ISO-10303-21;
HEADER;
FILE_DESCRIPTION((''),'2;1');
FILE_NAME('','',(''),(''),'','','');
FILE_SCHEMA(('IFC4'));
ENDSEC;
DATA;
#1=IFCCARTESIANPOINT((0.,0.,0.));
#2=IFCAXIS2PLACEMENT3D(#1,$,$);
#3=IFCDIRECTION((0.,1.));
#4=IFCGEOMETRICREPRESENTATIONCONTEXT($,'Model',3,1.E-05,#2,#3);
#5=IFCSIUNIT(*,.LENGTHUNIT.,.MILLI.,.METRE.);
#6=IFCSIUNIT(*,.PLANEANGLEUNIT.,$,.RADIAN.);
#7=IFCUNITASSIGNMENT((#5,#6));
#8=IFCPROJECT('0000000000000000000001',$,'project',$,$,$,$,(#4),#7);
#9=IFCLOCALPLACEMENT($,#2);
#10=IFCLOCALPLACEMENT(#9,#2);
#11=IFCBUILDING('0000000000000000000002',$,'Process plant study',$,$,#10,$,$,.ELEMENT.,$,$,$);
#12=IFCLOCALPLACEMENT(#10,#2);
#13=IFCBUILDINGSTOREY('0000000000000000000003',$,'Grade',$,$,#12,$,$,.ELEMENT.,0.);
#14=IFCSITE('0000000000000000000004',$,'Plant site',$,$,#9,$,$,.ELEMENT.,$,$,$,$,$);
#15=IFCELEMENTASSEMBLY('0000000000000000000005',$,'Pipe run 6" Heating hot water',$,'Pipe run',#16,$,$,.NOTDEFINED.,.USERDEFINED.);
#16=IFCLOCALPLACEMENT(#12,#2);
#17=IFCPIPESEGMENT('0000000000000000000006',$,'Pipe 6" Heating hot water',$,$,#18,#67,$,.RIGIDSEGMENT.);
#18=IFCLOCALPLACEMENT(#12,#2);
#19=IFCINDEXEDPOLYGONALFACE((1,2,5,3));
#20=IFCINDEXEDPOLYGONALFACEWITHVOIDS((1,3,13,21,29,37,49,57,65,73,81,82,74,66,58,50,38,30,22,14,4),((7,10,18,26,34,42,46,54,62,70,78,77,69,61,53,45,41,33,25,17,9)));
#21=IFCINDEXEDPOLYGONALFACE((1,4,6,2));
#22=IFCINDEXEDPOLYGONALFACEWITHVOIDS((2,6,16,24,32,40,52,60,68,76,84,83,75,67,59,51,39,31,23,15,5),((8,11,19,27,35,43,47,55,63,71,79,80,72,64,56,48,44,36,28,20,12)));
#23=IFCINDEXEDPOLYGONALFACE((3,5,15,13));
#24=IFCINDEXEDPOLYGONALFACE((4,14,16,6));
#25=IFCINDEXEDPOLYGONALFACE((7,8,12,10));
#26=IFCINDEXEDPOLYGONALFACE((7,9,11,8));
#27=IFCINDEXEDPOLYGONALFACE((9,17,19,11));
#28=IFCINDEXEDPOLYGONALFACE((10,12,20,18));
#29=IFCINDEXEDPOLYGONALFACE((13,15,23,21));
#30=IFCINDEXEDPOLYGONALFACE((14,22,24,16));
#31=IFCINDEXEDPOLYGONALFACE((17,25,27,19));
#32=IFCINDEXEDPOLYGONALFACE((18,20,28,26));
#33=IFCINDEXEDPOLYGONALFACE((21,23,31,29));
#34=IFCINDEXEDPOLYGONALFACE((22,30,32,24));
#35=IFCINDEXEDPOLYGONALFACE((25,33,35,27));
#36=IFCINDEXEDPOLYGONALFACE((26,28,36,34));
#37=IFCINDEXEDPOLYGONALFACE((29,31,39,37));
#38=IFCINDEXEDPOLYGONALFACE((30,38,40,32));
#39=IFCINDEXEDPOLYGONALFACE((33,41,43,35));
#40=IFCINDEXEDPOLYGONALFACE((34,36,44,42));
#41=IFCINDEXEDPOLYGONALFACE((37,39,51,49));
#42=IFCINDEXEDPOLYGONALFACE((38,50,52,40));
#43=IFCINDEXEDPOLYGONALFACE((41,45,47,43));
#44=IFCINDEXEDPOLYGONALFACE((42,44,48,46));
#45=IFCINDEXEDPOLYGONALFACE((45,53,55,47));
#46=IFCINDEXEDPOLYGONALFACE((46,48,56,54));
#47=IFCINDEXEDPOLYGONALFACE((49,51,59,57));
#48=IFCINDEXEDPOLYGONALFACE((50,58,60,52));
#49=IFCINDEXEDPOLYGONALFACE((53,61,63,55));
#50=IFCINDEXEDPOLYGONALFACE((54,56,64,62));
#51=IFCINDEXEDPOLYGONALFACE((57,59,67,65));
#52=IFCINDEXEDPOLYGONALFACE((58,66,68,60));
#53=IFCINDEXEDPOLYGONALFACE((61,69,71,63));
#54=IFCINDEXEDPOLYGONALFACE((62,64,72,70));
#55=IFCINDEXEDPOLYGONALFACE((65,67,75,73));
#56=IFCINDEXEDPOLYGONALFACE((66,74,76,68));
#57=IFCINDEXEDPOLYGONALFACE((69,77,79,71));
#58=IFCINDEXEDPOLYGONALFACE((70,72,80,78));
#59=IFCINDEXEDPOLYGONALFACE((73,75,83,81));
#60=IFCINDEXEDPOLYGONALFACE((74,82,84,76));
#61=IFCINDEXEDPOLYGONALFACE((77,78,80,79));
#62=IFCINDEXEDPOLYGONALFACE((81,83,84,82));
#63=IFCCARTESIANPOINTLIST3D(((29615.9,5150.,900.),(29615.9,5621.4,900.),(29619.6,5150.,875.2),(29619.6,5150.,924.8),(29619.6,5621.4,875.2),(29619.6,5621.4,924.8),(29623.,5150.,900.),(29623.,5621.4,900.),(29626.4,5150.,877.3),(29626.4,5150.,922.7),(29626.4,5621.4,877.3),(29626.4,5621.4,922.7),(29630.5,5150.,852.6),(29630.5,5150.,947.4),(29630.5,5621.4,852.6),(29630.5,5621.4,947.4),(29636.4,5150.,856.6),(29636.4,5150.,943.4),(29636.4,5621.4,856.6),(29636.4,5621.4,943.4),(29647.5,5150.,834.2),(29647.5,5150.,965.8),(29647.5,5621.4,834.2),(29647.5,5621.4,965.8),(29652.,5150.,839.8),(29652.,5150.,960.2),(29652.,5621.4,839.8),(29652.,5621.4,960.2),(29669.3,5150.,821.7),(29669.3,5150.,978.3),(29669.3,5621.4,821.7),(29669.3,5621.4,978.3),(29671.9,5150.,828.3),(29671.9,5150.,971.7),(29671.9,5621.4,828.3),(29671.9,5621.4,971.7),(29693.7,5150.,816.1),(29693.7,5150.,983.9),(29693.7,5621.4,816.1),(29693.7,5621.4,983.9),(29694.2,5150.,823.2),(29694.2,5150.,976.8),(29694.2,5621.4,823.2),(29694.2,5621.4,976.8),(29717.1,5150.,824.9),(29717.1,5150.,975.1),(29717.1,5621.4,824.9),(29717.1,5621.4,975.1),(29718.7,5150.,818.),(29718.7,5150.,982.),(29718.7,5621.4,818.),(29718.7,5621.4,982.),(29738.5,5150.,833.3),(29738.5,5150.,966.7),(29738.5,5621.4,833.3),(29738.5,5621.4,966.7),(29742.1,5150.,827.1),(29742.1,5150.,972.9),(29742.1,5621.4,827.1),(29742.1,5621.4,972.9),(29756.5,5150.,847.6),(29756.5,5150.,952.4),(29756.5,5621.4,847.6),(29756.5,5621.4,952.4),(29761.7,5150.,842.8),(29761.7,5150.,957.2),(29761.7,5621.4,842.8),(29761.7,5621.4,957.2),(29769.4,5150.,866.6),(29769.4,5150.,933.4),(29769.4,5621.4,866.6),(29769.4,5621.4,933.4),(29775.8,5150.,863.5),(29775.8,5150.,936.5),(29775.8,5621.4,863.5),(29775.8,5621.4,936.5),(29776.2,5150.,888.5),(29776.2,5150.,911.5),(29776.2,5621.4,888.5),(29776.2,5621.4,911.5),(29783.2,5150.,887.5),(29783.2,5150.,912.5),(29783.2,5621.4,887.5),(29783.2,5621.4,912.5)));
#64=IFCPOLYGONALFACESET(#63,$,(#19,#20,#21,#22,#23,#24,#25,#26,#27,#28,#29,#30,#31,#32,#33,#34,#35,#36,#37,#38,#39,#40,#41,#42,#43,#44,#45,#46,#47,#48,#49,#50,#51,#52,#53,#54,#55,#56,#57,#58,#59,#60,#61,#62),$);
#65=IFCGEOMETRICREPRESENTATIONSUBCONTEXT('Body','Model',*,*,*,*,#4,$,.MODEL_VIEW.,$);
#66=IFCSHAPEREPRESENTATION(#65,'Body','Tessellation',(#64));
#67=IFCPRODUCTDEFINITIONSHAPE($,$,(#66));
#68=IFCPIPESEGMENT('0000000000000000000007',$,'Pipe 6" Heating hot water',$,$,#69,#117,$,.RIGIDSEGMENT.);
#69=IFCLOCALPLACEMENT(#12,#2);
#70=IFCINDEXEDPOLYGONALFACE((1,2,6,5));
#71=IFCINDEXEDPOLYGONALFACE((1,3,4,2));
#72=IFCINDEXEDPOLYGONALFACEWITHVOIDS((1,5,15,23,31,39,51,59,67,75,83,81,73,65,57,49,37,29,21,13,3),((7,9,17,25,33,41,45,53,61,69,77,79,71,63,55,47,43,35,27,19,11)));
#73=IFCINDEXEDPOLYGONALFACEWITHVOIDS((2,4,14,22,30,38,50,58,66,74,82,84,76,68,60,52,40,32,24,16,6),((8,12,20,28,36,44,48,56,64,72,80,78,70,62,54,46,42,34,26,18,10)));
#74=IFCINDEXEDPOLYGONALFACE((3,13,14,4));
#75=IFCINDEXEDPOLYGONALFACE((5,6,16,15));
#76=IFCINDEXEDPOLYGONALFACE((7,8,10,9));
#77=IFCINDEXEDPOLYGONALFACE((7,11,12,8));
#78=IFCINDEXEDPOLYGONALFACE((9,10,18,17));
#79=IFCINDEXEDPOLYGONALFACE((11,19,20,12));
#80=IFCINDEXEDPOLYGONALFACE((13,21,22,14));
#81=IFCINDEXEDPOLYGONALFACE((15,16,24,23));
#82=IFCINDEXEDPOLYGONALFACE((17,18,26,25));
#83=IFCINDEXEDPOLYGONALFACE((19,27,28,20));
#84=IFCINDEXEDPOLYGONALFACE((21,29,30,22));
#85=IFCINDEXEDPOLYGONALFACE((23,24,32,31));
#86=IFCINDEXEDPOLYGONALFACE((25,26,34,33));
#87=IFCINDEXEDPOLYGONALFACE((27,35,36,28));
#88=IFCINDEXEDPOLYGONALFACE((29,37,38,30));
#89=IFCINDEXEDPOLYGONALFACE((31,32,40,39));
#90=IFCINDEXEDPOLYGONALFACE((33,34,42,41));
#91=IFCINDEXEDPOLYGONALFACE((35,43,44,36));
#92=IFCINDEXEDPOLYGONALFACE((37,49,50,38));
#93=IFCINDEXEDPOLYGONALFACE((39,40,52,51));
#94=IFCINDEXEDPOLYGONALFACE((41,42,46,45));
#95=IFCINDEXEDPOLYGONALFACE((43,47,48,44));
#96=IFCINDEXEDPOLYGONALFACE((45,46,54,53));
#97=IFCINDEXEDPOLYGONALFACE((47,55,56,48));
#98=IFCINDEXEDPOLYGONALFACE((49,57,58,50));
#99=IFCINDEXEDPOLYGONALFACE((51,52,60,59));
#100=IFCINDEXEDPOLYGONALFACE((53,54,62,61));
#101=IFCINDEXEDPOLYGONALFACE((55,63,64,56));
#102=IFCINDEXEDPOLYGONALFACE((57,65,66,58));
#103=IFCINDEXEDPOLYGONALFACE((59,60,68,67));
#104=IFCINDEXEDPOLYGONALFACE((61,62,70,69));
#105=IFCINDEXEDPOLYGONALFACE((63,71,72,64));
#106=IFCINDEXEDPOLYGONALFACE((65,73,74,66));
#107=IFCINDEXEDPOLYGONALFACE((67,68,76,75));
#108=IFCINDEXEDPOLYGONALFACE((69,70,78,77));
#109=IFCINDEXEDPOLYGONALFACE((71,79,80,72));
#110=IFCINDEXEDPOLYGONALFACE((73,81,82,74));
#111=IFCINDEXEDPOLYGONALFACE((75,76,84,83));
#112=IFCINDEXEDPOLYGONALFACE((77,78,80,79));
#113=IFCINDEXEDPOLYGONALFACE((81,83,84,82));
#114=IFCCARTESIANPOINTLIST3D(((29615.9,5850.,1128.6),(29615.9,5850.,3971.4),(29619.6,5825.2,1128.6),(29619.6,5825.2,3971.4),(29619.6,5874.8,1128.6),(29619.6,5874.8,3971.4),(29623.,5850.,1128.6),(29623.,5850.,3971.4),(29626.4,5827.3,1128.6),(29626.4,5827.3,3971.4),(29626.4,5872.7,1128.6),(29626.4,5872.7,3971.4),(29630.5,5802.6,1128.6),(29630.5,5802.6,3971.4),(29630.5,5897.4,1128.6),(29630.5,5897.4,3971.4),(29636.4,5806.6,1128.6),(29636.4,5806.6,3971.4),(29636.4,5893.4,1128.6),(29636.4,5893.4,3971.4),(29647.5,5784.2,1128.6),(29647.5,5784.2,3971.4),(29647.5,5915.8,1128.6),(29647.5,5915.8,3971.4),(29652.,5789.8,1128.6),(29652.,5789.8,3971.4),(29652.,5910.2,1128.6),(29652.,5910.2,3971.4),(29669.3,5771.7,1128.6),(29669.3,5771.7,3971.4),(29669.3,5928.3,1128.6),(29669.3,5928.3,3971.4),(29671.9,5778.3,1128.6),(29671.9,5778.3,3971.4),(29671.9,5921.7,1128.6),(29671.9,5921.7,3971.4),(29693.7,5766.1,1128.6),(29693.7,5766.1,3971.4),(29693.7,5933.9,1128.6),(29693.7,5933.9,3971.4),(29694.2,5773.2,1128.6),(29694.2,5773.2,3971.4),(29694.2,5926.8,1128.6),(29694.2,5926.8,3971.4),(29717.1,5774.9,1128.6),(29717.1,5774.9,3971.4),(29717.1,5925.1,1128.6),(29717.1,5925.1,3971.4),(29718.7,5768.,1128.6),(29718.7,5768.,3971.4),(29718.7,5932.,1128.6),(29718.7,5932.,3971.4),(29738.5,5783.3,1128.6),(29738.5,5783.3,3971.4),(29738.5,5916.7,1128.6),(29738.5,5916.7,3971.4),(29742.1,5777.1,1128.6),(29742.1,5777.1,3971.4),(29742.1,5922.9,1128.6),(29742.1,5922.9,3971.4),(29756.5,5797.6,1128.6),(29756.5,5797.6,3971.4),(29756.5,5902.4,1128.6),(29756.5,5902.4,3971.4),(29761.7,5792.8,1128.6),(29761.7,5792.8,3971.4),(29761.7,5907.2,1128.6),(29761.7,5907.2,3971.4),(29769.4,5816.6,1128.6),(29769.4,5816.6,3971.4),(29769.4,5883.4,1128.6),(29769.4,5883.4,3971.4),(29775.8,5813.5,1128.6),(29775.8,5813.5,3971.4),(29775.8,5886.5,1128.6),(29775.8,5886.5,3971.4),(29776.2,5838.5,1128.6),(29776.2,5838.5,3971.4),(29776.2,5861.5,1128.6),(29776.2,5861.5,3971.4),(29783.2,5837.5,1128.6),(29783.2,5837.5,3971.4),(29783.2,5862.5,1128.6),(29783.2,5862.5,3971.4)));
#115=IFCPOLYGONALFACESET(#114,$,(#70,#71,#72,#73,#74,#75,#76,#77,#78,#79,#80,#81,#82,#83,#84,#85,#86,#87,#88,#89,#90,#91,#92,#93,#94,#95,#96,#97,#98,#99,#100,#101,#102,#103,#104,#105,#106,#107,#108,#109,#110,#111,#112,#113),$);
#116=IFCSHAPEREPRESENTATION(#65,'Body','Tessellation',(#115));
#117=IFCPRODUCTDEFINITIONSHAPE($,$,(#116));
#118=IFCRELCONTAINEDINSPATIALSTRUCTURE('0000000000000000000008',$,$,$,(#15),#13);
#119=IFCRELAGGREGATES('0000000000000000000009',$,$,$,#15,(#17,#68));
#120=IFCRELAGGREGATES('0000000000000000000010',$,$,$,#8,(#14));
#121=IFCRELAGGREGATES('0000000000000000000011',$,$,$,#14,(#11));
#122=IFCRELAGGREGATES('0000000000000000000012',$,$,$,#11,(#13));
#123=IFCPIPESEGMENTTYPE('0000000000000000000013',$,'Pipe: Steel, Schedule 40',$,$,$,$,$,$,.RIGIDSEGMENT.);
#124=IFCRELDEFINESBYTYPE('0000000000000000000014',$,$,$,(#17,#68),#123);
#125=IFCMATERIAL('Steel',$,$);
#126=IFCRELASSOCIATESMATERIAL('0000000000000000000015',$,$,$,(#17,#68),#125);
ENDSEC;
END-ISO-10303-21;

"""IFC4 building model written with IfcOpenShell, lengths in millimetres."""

from ifc_helpers import new_model, si_unit, direction, frame, origin, origin_with_axes, origin_2d, place, context, subcontext, project, spatial, hollow_circle, extrude, material, type_object, element, aggregate, save


model = new_model("IFC4")

# Units and contexts
model_context = context("Model", 3, precision=1e-05, world=origin(), true_north=direction((0.0, 1.0)))
body_context = subcontext(model_context, "Body", "Model", "MODEL_VIEW")
ifc_project = project(units=[si_unit("LENGTHUNIT", "METRE", prefix="MILLI"), si_unit("PLANEANGLEUNIT", "RADIAN")], contexts=[model_context])

# Site, building, storey
site_placement = place(None, origin())
site = spatial("IfcSite", under=ifc_project, at=site_placement, Name="Plant site", CompositionType="ELEMENT")
building_placement = place(site_placement, origin())
building = spatial("IfcBuilding", under=site, at=building_placement, Name="Process plant study", CompositionType="ELEMENT")
storey_placement = place(building_placement, origin())
storey = spatial("IfcBuildingStorey", under=building, at=storey_placement, Name="Grade", CompositionType="ELEMENT", Elevation=0.0)

# Element assembly, pipe segments
ifc_material = material(Name="Steel")
pipe_segment_type = type_object("IfcPipeSegmentType", Name="Pipe: Steel, Schedule 40", PredefinedType="RIGIDSEGMENT")
assembly_1_placement = place(storey_placement, origin_with_axes())
assembly_1 = element("IfcElementAssembly", 1, at=assembly_1_placement, inside=storey, Name="Pipe run 6\" Heating hot water", ObjectType="Pipe run", AssemblyPlace="NOTDEFINED", PredefinedType="USERDEFINED")
pipe_segment_1_placement = place(storey_placement, origin_with_axes())
pipe_segment_1 = element("IfcPipeSegment", 2, at=pipe_segment_1_placement, type_object=pipe_segment_type, material=ifc_material, Name="Pipe 6\" Heating hot water", PredefinedType="RIGIDSEGMENT", context=body_context, shape_type="SweptSolid", body=[
    extrude(hollow_circle(Radius=84.1, WallThickness=7.1, at=origin_2d()), frame((29700.0, 5150.0, 900.0), z_axis=(0.0, 1.0, 0.0), x_axis=(-1.0, 0.0, 0.0)), (0.0, 0.0, 1.0), 471.4),
])
pipe_segment_2_placement = place(storey_placement, origin_with_axes())
pipe_segment_2 = element("IfcPipeSegment", 3, at=pipe_segment_2_placement, type_object=pipe_segment_type, material=ifc_material, Name="Pipe 6\" Heating hot water", PredefinedType="RIGIDSEGMENT", context=body_context, shape_type="SweptSolid", body=[
    extrude(hollow_circle(Radius=84.1, WallThickness=7.1, at=origin_2d()), frame((29700.0, 5850.0, 1128.6), z_axis=(0.0, 0.0, 1.0), x_axis=(-1.0, 0.0, 0.0)), (0.0, 0.0, 1.0), 2842.8),
])

aggregate(assembly_1, [pipe_segment_1, pipe_segment_2])

save(model, "model.ifc")
